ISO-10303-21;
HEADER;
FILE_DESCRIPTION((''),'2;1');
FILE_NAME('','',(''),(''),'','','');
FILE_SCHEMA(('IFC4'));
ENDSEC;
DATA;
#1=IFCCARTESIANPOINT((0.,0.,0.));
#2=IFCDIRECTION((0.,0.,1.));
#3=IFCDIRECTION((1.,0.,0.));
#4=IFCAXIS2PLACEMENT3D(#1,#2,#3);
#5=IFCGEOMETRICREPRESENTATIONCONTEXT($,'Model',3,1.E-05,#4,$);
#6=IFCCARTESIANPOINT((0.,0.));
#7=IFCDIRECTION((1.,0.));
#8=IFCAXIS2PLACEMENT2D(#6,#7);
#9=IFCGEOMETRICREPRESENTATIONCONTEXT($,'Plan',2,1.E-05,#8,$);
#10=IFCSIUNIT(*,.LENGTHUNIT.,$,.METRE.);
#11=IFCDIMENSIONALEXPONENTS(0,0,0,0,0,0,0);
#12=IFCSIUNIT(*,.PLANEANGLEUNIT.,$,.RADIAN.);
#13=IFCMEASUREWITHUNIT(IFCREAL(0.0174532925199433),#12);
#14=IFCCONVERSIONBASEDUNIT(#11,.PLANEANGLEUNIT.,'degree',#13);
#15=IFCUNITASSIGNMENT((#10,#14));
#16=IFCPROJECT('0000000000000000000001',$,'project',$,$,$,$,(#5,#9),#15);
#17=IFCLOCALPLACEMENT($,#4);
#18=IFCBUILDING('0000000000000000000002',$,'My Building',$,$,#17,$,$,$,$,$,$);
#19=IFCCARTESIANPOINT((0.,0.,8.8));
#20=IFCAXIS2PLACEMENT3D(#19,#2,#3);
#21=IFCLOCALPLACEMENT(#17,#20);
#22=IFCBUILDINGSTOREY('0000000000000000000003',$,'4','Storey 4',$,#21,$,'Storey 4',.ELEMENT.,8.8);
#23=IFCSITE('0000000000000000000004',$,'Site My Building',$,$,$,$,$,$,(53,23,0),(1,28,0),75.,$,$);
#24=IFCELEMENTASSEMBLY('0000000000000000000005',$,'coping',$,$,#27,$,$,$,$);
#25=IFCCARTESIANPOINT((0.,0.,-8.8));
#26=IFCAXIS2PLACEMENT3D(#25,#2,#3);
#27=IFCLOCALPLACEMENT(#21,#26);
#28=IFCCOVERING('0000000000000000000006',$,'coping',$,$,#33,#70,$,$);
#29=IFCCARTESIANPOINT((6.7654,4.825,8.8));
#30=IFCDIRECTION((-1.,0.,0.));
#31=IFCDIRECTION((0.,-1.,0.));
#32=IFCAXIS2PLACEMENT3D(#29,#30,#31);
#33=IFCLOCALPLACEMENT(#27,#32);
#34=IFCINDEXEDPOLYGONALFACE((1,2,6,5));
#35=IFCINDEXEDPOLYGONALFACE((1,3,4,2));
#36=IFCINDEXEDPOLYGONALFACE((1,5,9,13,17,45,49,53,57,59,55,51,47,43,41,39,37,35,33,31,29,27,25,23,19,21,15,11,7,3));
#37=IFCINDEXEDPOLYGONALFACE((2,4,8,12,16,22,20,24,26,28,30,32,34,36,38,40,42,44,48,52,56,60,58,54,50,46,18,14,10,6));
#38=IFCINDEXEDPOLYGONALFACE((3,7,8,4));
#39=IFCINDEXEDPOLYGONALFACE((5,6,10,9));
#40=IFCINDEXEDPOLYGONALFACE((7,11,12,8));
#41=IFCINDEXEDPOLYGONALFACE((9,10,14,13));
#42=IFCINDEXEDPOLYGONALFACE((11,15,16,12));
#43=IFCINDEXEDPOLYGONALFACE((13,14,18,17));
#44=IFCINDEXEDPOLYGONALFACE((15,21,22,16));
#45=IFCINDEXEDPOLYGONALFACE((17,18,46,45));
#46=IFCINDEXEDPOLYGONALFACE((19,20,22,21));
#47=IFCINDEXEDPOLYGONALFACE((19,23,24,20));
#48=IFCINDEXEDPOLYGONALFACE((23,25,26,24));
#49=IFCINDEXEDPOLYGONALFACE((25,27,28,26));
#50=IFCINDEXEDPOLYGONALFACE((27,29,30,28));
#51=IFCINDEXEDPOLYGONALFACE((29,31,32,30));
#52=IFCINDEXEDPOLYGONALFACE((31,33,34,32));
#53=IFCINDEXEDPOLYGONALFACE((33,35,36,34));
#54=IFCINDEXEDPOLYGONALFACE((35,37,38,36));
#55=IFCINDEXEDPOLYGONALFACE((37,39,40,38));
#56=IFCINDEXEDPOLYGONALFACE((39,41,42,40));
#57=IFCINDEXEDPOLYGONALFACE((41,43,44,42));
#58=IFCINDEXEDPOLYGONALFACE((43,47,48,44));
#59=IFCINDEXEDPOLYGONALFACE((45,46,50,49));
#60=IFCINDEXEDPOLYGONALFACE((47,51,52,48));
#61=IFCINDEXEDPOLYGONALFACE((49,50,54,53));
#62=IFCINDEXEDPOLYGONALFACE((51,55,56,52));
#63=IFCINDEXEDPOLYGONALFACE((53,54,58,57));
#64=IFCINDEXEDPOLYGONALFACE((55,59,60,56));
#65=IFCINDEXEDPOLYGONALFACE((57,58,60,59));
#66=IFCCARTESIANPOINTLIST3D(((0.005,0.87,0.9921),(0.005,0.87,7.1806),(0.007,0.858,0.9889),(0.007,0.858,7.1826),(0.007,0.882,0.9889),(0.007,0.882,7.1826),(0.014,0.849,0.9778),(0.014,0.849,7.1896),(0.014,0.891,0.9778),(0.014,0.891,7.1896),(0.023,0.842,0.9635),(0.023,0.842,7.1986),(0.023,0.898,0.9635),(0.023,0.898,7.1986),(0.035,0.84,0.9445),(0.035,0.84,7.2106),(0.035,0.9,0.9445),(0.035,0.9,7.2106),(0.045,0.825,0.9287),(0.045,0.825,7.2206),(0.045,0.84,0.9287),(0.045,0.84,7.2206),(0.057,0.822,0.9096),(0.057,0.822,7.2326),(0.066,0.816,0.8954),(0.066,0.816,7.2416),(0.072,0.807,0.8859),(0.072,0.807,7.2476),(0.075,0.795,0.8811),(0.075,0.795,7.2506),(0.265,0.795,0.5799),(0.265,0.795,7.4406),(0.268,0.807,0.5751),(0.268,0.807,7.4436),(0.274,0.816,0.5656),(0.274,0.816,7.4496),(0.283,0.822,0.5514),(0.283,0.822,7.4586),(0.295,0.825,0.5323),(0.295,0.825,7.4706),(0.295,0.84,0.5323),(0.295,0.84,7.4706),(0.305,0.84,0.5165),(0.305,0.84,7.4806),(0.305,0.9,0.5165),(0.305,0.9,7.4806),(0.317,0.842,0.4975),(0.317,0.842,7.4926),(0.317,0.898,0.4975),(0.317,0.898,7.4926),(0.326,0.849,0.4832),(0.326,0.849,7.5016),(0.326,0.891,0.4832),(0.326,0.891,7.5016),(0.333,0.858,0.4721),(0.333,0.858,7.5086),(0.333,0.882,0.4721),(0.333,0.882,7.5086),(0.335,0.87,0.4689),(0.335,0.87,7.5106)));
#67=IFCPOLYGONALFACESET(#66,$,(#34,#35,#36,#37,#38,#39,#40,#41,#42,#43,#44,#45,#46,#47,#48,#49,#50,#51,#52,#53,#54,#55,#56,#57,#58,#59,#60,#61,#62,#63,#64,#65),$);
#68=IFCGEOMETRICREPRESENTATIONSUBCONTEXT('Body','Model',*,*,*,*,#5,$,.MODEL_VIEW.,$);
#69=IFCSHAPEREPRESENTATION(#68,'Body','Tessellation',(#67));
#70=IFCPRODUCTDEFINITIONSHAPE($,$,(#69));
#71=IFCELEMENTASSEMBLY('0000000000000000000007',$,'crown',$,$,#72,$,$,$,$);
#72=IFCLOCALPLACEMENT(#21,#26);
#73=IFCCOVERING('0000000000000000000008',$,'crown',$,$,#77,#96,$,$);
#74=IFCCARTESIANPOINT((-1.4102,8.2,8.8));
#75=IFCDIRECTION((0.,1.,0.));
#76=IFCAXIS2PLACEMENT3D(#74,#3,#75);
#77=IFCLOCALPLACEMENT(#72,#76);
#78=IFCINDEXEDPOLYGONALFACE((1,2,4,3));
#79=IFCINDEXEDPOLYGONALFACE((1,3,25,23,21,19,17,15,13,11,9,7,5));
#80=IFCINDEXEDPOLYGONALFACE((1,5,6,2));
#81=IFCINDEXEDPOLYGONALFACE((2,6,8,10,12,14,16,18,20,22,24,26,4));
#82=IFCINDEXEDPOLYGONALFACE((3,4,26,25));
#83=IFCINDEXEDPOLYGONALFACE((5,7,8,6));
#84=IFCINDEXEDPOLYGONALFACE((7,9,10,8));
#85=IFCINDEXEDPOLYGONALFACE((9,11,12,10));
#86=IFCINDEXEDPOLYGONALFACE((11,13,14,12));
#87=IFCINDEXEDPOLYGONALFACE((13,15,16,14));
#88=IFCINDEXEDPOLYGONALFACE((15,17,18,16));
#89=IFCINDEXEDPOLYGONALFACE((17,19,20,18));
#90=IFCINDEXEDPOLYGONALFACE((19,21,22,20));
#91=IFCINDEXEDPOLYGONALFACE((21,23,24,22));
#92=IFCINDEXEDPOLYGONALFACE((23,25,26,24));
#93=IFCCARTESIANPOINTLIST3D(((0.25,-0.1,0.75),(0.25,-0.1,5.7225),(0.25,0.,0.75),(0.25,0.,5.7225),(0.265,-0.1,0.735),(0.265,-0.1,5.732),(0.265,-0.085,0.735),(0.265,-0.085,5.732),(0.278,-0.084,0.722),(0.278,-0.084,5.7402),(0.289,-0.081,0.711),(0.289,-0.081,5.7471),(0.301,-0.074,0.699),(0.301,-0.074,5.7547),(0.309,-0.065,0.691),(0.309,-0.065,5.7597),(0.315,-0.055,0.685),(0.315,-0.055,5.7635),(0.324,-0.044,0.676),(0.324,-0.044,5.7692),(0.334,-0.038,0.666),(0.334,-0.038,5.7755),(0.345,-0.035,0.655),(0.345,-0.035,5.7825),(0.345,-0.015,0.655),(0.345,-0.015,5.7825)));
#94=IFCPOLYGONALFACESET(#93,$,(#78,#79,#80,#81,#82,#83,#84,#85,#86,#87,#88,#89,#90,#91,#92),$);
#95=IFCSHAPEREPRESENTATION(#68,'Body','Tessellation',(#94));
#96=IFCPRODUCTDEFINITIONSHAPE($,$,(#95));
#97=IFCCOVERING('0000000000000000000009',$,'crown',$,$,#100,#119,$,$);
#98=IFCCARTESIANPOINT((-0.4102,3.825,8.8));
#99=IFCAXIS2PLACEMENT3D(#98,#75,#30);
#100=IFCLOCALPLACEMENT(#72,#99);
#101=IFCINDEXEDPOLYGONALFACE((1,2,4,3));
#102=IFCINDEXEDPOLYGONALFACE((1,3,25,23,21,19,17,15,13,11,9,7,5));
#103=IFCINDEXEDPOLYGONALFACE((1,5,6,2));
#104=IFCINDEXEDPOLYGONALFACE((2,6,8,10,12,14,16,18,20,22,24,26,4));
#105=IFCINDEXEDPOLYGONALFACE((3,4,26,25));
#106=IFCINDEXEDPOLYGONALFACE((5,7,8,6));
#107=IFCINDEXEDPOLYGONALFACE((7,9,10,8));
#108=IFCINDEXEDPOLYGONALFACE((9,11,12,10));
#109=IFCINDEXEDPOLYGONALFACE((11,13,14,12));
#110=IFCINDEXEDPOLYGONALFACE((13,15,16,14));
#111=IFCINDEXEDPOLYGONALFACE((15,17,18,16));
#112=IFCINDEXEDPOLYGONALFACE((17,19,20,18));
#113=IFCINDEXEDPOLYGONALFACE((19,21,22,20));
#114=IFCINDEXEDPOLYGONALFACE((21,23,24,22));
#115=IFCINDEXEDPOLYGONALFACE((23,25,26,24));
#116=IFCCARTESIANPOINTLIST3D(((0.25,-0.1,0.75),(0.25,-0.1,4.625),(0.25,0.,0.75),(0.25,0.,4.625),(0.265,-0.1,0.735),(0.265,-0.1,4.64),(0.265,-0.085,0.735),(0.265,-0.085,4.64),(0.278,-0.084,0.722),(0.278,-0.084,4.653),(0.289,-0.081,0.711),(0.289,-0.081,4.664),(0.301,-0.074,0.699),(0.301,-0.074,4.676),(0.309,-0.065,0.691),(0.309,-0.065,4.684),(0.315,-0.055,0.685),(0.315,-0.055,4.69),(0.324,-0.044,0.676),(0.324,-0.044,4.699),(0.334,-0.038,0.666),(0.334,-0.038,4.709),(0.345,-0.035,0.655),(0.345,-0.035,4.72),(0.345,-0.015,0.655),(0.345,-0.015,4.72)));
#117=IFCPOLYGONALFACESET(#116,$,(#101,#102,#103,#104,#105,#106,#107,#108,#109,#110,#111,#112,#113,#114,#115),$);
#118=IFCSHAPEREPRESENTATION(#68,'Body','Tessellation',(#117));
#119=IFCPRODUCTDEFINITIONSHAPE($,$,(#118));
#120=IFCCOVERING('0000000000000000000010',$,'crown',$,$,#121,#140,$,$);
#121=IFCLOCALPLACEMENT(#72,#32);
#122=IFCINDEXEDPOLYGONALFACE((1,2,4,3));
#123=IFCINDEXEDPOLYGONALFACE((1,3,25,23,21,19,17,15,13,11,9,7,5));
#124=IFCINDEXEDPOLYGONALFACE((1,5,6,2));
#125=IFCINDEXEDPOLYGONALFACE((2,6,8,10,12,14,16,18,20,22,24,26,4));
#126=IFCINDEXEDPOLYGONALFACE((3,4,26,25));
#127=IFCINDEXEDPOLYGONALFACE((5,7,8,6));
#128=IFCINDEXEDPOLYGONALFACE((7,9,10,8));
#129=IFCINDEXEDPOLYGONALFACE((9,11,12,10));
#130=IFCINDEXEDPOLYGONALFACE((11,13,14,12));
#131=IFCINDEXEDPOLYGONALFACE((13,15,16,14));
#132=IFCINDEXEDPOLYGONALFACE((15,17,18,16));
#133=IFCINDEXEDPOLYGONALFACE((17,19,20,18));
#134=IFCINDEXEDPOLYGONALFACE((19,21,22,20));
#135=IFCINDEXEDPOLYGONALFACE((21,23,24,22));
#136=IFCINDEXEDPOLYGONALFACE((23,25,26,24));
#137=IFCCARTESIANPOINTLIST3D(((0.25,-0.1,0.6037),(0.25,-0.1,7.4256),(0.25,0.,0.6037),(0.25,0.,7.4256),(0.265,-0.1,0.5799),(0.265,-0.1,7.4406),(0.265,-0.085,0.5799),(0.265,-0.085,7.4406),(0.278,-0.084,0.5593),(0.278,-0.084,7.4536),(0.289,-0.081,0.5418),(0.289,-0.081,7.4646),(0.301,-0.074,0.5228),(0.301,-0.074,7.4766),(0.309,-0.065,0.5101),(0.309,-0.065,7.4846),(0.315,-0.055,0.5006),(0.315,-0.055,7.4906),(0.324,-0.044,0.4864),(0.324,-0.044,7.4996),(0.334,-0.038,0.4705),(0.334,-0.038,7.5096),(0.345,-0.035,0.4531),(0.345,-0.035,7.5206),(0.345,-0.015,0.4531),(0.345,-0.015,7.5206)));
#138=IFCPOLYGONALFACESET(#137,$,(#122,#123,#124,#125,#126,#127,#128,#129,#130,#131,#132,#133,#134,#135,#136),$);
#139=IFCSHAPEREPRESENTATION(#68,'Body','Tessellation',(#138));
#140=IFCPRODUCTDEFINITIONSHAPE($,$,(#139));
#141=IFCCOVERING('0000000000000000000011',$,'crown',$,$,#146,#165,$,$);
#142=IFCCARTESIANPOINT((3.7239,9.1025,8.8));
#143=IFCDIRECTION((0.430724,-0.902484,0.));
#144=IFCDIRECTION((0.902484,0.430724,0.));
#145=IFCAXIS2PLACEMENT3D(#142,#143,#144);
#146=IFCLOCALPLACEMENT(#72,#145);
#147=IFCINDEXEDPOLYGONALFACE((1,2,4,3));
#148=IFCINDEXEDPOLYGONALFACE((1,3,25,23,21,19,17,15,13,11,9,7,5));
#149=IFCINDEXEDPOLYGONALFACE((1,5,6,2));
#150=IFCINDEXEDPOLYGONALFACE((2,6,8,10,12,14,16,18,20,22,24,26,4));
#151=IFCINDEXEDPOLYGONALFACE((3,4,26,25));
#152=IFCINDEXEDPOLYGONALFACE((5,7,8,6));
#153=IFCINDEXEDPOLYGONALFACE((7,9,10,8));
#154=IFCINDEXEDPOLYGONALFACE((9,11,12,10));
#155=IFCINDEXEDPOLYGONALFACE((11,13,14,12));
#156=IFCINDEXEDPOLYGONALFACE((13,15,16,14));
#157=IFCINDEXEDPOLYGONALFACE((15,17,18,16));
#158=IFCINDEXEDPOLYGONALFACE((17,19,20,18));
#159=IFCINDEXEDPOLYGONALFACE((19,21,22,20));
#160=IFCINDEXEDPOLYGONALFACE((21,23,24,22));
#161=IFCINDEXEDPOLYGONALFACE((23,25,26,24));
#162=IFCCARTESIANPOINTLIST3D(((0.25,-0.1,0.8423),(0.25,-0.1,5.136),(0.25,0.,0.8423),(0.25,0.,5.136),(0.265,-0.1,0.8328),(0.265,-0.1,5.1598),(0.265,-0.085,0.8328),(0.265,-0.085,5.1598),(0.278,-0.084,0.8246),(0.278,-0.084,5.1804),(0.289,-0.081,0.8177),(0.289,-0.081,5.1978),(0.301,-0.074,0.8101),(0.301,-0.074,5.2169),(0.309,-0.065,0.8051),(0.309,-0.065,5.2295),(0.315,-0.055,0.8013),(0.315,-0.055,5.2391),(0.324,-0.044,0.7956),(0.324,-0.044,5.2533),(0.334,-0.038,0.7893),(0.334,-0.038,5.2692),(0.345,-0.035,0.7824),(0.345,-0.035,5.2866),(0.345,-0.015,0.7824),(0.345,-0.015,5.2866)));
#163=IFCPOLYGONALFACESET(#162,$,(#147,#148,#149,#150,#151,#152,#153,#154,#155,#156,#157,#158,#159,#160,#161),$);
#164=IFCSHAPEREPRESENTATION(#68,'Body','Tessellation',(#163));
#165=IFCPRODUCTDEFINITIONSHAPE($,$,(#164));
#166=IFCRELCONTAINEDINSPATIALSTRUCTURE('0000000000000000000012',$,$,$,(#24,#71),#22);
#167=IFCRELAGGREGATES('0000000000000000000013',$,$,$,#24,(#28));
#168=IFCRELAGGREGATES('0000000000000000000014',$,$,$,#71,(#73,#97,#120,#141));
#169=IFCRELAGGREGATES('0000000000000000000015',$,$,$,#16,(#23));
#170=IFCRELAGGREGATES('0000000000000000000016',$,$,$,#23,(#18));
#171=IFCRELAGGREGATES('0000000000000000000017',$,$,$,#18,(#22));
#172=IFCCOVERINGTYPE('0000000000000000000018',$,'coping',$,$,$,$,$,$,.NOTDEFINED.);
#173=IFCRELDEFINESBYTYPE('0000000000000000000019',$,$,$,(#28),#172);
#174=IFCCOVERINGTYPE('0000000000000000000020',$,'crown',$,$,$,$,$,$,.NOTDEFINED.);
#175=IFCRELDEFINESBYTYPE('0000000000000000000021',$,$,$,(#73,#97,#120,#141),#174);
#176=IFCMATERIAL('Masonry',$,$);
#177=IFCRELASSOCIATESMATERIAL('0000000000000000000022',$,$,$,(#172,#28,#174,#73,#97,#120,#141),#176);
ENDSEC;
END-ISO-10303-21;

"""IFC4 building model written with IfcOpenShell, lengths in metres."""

from ifc_helpers import new_model, entity, si_unit, converted_unit, frame, origin_with_axes, origin_2d_with_axis, place, context, subcontext, project, spatial, polyline, outline, extrude, clip, halfspace, material, material_profile, profile_set, profile_usage, type_object, element, aggregate, save


model = new_model("IFC4")

# Units and contexts
model_context = context("Model", 3, precision=1e-05, world=origin_with_axes())
plan_context = context("Plan", 2, precision=1e-05, world=origin_2d_with_axis())
body_context = subcontext(model_context, "Body", "Model", "MODEL_VIEW")
ifc_project = project(units=[si_unit("LENGTHUNIT", "METRE"), converted_unit("PLANEANGLEUNIT", "degree", entity("IfcReal", 0.0174532925199433), si_unit("PLANEANGLEUNIT", "RADIAN"), dimensions=[0, 0, 0, 0, 0, 0, 0])], contexts=[model_context, plan_context])

# Site, building, storey
site = spatial("IfcSite", under=ifc_project, Name="Site My Building", RefLatitude=(53, 23, 0), RefLongitude=(1, 28, 0), RefElevation=75.0)
building_placement = place(None, origin_with_axes())
building = spatial("IfcBuilding", under=site, at=building_placement, Name="My Building")
storey_placement = place(building_placement, frame((0.0, 0.0, 8.8), z_axis=(0.0, 0.0, 1.0), x_axis=(1.0, 0.0, 0.0)))
storey = spatial("IfcBuildingStorey", under=building, at=storey_placement, Name="4", Description="Storey 4", LongName="Storey 4", CompositionType="ELEMENT", Elevation=8.8)

# Shared definitions
ifc_material_1 = material(Name="Masonry")

# Element assemblies, coverings
assembly_1_placement = place(storey_placement, frame((0.0, 0.0, -8.8), z_axis=(0.0, 0.0, 1.0), x_axis=(1.0, 0.0, 0.0)))
assembly_1 = element("IfcElementAssembly", 1, at=assembly_1_placement, inside=storey, Name="coping")
ifc_material_profile_1 = material_profile(ifc_material_1, outline(polyline([(0.265, 0.795), (0.268, 0.807), (0.274, 0.816), (0.283, 0.822), (0.295, 0.825), (0.295, 0.84), (0.305, 0.84), (0.317, 0.842), (0.326, 0.849), (0.333, 0.858), (0.335, 0.87), (0.333, 0.882), (0.326, 0.891), (0.317, 0.898), (0.305, 0.9), (0.035, 0.9), (0.023, 0.898), (0.014, 0.891), (0.007, 0.882), (0.005, 0.87), (0.007, 0.858), (0.014, 0.849), (0.023, 0.842), (0.035, 0.84), (0.045, 0.84), (0.045, 0.825), (0.057, 0.822), (0.066, 0.816), (0.072, 0.807), (0.075, 0.795), (0.265, 0.795)])))
ifc_profile_set_1 = profile_set([ifc_material_profile_1])
covering_type_1 = type_object("IfcCoveringType", Name="coping", PredefinedType="NOTDEFINED", material=ifc_profile_set_1)
ifc_profile_usage_1 = profile_usage(ifc_profile_set_1)
covering_1_placement = place(assembly_1_placement, frame((6.7654, 4.825, 8.8), z_axis=(-1.0, 0.0, 0.0), x_axis=(0.0, -1.0, 0.0)))
covering_1 = element("IfcCovering", 2, at=covering_1_placement, type_object=covering_type_1, material=ifc_profile_usage_1, Name="coping", context=body_context, shape_type="Clipping", body=[
    clip(clip(extrude(outline(polyline([(0.265, 0.795), (0.268, 0.807), (0.274, 0.816), (0.283, 0.822), (0.295, 0.825), (0.295, 0.84), (0.305, 0.84), (0.317, 0.842), (0.326, 0.849), (0.333, 0.858), (0.335, 0.87), (0.333, 0.882), (0.326, 0.891), (0.317, 0.898), (0.305, 0.9), (0.035, 0.9), (0.023, 0.898), (0.014, 0.891), (0.007, 0.882), (0.005, 0.87), (0.007, 0.858), (0.014, 0.849), (0.023, 0.842), (0.035, 0.84), (0.045, 0.84), (0.045, 0.825), (0.057, 0.822), (0.066, 0.816), (0.072, 0.807), (0.075, 0.795), (0.265, 0.795)])), origin_with_axes(), (0.0, 0.0, 1.0), 8.1756), halfspace(frame((0.0, -8.8, 1.0), z_axis=(-0.845791, 0.0, -0.533515), x_axis=(0.0, 1.0, 0.0)), False)), halfspace(frame((0.0, -8.8, 7.1756), z_axis=(-0.707107, 0.0, 0.707107), x_axis=(0.0, 1.0, 0.0)), False)),
])
aggregate(assembly_1, [covering_1])
assembly_2_placement = place(storey_placement, frame((0.0, 0.0, -8.8), z_axis=(0.0, 0.0, 1.0), x_axis=(1.0, 0.0, 0.0)))
assembly_2 = element("IfcElementAssembly", 3, at=assembly_2_placement, inside=storey, Name="crown")
ifc_material_profile_2 = material_profile(ifc_material_1, outline(polyline([(0.25, -0.1), (0.265, -0.1), (0.265, -0.085), (0.278, -0.084), (0.289, -0.081), (0.301, -0.074), (0.309, -0.065), (0.315, -0.055), (0.324, -0.044), (0.334, -0.038), (0.345, -0.035), (0.345, -0.015), (0.25, 0.0), (0.25, -0.1)])))
ifc_profile_set_2 = profile_set([ifc_material_profile_2])
ifc_profile_usage_2 = profile_usage(ifc_profile_set_2)
covering_type_2 = type_object("IfcCoveringType", Name="crown", PredefinedType="NOTDEFINED", material=ifc_profile_set_2)
covering_2_placement = place(assembly_2_placement, frame((-1.4102, 8.2, 8.8), z_axis=(1.0, 0.0, 0.0), x_axis=(0.0, 1.0, 0.0)))
covering_2 = element("IfcCovering", 4, at=covering_2_placement, type_object=covering_type_2, material=ifc_profile_usage_2, Name="crown", context=body_context, shape_type="Clipping", body=[
    clip(clip(extrude(outline(polyline([(0.25, -0.1), (0.265, -0.1), (0.265, -0.085), (0.278, -0.084), (0.289, -0.081), (0.301, -0.074), (0.309, -0.065), (0.315, -0.055), (0.324, -0.044), (0.334, -0.038), (0.345, -0.035), (0.345, -0.015), (0.25, 0.0), (0.25, -0.1)])), origin_with_axes(), (0.0, 0.0, 1.0), 6.5648), halfspace(frame((0.0, -8.8, 1.0), z_axis=(-0.707107, 0.0, -0.707107), x_axis=(0.0, 1.0, 0.0)), False)), halfspace(frame((0.0, -8.8, 5.5648), z_axis=(-0.533515, 0.0, 0.845791), x_axis=(0.0, 1.0, 0.0)), False)),
])
ifc_profile_usage_3 = profile_usage(ifc_profile_set_2)
covering_3_placement = place(assembly_2_placement, frame((-0.4102, 3.825, 8.8), z_axis=(0.0, 1.0, 0.0), x_axis=(-1.0, 0.0, 0.0)))
covering_3 = element("IfcCovering", 5, at=covering_3_placement, type_object=covering_type_2, material=ifc_profile_usage_3, Name="crown", context=body_context, shape_type="Clipping", body=[
    clip(clip(extrude(outline(polyline([(0.25, -0.1), (0.265, -0.1), (0.265, -0.085), (0.278, -0.084), (0.289, -0.081), (0.301, -0.074), (0.309, -0.065), (0.315, -0.055), (0.324, -0.044), (0.334, -0.038), (0.345, -0.035), (0.345, -0.015), (0.25, 0.0), (0.25, -0.1)])), origin_with_axes(), (0.0, 0.0, 1.0), 5.375), halfspace(frame((0.0, -8.8, 1.0), z_axis=(-0.707107, 0.0, -0.707107), x_axis=(0.0, 1.0, 0.0)), False)), halfspace(frame((0.0, -8.8, 4.375), z_axis=(-0.707107, 0.0, 0.707107), x_axis=(0.0, 1.0, 0.0)), False)),
])
ifc_profile_usage_4 = profile_usage(ifc_profile_set_2)
covering_4_placement = place(assembly_2_placement, frame((6.7654, 4.825, 8.8), z_axis=(-1.0, 0.0, 0.0), x_axis=(0.0, -1.0, 0.0)))
covering_4 = element("IfcCovering", 6, at=covering_4_placement, type_object=covering_type_2, material=ifc_profile_usage_4, Name="crown", context=body_context, shape_type="Clipping", body=[
    clip(clip(extrude(outline(polyline([(0.25, -0.1), (0.265, -0.1), (0.265, -0.085), (0.278, -0.084), (0.289, -0.081), (0.301, -0.074), (0.309, -0.065), (0.315, -0.055), (0.324, -0.044), (0.334, -0.038), (0.345, -0.035), (0.345, -0.015), (0.25, 0.0), (0.25, -0.1)])), origin_with_axes(), (0.0, 0.0, 1.0), 8.1756), halfspace(frame((0.0, -8.8, 1.0), z_axis=(-0.845791, 0.0, -0.533515), x_axis=(0.0, 1.0, 0.0)), False)), halfspace(frame((0.0, -8.8, 7.1756), z_axis=(-0.707107, 0.0, 0.707107), x_axis=(0.0, 1.0, 0.0)), False)),
])
ifc_profile_usage_5 = profile_usage(ifc_profile_set_2)
covering_5_placement = place(assembly_2_placement, frame((3.7239, 9.1025, 8.8), z_axis=(0.430724, -0.902484, 0.0), x_axis=(0.902484, 0.430724, 0.0)))
covering_5 = element("IfcCovering", 7, at=covering_5_placement, type_object=covering_type_2, material=ifc_profile_usage_5, Name="crown", context=body_context, shape_type="Clipping", body=[
    clip(clip(extrude(outline(polyline([(0.25, -0.1), (0.265, -0.1), (0.265, -0.085), (0.278, -0.084), (0.289, -0.081), (0.301, -0.074), (0.309, -0.065), (0.315, -0.055), (0.324, -0.044), (0.334, -0.038), (0.345, -0.035), (0.345, -0.015), (0.25, 0.0), (0.25, -0.1)])), origin_with_axes(), (0.0, 0.0, 1.0), 5.7397), halfspace(frame((0.0, -8.8, 1.0), z_axis=(-0.533515, 0.0, -0.845791), x_axis=(0.0, 1.0, 0.0)), False)), halfspace(frame((0.0, -8.8, 4.7397), z_axis=(-0.845791, 0.0, 0.533515), x_axis=(0.0, 1.0, 0.0)), False)),
])
aggregate(assembly_2, [covering_2, covering_3, covering_4, covering_5])

save(model, "model.ifc")
